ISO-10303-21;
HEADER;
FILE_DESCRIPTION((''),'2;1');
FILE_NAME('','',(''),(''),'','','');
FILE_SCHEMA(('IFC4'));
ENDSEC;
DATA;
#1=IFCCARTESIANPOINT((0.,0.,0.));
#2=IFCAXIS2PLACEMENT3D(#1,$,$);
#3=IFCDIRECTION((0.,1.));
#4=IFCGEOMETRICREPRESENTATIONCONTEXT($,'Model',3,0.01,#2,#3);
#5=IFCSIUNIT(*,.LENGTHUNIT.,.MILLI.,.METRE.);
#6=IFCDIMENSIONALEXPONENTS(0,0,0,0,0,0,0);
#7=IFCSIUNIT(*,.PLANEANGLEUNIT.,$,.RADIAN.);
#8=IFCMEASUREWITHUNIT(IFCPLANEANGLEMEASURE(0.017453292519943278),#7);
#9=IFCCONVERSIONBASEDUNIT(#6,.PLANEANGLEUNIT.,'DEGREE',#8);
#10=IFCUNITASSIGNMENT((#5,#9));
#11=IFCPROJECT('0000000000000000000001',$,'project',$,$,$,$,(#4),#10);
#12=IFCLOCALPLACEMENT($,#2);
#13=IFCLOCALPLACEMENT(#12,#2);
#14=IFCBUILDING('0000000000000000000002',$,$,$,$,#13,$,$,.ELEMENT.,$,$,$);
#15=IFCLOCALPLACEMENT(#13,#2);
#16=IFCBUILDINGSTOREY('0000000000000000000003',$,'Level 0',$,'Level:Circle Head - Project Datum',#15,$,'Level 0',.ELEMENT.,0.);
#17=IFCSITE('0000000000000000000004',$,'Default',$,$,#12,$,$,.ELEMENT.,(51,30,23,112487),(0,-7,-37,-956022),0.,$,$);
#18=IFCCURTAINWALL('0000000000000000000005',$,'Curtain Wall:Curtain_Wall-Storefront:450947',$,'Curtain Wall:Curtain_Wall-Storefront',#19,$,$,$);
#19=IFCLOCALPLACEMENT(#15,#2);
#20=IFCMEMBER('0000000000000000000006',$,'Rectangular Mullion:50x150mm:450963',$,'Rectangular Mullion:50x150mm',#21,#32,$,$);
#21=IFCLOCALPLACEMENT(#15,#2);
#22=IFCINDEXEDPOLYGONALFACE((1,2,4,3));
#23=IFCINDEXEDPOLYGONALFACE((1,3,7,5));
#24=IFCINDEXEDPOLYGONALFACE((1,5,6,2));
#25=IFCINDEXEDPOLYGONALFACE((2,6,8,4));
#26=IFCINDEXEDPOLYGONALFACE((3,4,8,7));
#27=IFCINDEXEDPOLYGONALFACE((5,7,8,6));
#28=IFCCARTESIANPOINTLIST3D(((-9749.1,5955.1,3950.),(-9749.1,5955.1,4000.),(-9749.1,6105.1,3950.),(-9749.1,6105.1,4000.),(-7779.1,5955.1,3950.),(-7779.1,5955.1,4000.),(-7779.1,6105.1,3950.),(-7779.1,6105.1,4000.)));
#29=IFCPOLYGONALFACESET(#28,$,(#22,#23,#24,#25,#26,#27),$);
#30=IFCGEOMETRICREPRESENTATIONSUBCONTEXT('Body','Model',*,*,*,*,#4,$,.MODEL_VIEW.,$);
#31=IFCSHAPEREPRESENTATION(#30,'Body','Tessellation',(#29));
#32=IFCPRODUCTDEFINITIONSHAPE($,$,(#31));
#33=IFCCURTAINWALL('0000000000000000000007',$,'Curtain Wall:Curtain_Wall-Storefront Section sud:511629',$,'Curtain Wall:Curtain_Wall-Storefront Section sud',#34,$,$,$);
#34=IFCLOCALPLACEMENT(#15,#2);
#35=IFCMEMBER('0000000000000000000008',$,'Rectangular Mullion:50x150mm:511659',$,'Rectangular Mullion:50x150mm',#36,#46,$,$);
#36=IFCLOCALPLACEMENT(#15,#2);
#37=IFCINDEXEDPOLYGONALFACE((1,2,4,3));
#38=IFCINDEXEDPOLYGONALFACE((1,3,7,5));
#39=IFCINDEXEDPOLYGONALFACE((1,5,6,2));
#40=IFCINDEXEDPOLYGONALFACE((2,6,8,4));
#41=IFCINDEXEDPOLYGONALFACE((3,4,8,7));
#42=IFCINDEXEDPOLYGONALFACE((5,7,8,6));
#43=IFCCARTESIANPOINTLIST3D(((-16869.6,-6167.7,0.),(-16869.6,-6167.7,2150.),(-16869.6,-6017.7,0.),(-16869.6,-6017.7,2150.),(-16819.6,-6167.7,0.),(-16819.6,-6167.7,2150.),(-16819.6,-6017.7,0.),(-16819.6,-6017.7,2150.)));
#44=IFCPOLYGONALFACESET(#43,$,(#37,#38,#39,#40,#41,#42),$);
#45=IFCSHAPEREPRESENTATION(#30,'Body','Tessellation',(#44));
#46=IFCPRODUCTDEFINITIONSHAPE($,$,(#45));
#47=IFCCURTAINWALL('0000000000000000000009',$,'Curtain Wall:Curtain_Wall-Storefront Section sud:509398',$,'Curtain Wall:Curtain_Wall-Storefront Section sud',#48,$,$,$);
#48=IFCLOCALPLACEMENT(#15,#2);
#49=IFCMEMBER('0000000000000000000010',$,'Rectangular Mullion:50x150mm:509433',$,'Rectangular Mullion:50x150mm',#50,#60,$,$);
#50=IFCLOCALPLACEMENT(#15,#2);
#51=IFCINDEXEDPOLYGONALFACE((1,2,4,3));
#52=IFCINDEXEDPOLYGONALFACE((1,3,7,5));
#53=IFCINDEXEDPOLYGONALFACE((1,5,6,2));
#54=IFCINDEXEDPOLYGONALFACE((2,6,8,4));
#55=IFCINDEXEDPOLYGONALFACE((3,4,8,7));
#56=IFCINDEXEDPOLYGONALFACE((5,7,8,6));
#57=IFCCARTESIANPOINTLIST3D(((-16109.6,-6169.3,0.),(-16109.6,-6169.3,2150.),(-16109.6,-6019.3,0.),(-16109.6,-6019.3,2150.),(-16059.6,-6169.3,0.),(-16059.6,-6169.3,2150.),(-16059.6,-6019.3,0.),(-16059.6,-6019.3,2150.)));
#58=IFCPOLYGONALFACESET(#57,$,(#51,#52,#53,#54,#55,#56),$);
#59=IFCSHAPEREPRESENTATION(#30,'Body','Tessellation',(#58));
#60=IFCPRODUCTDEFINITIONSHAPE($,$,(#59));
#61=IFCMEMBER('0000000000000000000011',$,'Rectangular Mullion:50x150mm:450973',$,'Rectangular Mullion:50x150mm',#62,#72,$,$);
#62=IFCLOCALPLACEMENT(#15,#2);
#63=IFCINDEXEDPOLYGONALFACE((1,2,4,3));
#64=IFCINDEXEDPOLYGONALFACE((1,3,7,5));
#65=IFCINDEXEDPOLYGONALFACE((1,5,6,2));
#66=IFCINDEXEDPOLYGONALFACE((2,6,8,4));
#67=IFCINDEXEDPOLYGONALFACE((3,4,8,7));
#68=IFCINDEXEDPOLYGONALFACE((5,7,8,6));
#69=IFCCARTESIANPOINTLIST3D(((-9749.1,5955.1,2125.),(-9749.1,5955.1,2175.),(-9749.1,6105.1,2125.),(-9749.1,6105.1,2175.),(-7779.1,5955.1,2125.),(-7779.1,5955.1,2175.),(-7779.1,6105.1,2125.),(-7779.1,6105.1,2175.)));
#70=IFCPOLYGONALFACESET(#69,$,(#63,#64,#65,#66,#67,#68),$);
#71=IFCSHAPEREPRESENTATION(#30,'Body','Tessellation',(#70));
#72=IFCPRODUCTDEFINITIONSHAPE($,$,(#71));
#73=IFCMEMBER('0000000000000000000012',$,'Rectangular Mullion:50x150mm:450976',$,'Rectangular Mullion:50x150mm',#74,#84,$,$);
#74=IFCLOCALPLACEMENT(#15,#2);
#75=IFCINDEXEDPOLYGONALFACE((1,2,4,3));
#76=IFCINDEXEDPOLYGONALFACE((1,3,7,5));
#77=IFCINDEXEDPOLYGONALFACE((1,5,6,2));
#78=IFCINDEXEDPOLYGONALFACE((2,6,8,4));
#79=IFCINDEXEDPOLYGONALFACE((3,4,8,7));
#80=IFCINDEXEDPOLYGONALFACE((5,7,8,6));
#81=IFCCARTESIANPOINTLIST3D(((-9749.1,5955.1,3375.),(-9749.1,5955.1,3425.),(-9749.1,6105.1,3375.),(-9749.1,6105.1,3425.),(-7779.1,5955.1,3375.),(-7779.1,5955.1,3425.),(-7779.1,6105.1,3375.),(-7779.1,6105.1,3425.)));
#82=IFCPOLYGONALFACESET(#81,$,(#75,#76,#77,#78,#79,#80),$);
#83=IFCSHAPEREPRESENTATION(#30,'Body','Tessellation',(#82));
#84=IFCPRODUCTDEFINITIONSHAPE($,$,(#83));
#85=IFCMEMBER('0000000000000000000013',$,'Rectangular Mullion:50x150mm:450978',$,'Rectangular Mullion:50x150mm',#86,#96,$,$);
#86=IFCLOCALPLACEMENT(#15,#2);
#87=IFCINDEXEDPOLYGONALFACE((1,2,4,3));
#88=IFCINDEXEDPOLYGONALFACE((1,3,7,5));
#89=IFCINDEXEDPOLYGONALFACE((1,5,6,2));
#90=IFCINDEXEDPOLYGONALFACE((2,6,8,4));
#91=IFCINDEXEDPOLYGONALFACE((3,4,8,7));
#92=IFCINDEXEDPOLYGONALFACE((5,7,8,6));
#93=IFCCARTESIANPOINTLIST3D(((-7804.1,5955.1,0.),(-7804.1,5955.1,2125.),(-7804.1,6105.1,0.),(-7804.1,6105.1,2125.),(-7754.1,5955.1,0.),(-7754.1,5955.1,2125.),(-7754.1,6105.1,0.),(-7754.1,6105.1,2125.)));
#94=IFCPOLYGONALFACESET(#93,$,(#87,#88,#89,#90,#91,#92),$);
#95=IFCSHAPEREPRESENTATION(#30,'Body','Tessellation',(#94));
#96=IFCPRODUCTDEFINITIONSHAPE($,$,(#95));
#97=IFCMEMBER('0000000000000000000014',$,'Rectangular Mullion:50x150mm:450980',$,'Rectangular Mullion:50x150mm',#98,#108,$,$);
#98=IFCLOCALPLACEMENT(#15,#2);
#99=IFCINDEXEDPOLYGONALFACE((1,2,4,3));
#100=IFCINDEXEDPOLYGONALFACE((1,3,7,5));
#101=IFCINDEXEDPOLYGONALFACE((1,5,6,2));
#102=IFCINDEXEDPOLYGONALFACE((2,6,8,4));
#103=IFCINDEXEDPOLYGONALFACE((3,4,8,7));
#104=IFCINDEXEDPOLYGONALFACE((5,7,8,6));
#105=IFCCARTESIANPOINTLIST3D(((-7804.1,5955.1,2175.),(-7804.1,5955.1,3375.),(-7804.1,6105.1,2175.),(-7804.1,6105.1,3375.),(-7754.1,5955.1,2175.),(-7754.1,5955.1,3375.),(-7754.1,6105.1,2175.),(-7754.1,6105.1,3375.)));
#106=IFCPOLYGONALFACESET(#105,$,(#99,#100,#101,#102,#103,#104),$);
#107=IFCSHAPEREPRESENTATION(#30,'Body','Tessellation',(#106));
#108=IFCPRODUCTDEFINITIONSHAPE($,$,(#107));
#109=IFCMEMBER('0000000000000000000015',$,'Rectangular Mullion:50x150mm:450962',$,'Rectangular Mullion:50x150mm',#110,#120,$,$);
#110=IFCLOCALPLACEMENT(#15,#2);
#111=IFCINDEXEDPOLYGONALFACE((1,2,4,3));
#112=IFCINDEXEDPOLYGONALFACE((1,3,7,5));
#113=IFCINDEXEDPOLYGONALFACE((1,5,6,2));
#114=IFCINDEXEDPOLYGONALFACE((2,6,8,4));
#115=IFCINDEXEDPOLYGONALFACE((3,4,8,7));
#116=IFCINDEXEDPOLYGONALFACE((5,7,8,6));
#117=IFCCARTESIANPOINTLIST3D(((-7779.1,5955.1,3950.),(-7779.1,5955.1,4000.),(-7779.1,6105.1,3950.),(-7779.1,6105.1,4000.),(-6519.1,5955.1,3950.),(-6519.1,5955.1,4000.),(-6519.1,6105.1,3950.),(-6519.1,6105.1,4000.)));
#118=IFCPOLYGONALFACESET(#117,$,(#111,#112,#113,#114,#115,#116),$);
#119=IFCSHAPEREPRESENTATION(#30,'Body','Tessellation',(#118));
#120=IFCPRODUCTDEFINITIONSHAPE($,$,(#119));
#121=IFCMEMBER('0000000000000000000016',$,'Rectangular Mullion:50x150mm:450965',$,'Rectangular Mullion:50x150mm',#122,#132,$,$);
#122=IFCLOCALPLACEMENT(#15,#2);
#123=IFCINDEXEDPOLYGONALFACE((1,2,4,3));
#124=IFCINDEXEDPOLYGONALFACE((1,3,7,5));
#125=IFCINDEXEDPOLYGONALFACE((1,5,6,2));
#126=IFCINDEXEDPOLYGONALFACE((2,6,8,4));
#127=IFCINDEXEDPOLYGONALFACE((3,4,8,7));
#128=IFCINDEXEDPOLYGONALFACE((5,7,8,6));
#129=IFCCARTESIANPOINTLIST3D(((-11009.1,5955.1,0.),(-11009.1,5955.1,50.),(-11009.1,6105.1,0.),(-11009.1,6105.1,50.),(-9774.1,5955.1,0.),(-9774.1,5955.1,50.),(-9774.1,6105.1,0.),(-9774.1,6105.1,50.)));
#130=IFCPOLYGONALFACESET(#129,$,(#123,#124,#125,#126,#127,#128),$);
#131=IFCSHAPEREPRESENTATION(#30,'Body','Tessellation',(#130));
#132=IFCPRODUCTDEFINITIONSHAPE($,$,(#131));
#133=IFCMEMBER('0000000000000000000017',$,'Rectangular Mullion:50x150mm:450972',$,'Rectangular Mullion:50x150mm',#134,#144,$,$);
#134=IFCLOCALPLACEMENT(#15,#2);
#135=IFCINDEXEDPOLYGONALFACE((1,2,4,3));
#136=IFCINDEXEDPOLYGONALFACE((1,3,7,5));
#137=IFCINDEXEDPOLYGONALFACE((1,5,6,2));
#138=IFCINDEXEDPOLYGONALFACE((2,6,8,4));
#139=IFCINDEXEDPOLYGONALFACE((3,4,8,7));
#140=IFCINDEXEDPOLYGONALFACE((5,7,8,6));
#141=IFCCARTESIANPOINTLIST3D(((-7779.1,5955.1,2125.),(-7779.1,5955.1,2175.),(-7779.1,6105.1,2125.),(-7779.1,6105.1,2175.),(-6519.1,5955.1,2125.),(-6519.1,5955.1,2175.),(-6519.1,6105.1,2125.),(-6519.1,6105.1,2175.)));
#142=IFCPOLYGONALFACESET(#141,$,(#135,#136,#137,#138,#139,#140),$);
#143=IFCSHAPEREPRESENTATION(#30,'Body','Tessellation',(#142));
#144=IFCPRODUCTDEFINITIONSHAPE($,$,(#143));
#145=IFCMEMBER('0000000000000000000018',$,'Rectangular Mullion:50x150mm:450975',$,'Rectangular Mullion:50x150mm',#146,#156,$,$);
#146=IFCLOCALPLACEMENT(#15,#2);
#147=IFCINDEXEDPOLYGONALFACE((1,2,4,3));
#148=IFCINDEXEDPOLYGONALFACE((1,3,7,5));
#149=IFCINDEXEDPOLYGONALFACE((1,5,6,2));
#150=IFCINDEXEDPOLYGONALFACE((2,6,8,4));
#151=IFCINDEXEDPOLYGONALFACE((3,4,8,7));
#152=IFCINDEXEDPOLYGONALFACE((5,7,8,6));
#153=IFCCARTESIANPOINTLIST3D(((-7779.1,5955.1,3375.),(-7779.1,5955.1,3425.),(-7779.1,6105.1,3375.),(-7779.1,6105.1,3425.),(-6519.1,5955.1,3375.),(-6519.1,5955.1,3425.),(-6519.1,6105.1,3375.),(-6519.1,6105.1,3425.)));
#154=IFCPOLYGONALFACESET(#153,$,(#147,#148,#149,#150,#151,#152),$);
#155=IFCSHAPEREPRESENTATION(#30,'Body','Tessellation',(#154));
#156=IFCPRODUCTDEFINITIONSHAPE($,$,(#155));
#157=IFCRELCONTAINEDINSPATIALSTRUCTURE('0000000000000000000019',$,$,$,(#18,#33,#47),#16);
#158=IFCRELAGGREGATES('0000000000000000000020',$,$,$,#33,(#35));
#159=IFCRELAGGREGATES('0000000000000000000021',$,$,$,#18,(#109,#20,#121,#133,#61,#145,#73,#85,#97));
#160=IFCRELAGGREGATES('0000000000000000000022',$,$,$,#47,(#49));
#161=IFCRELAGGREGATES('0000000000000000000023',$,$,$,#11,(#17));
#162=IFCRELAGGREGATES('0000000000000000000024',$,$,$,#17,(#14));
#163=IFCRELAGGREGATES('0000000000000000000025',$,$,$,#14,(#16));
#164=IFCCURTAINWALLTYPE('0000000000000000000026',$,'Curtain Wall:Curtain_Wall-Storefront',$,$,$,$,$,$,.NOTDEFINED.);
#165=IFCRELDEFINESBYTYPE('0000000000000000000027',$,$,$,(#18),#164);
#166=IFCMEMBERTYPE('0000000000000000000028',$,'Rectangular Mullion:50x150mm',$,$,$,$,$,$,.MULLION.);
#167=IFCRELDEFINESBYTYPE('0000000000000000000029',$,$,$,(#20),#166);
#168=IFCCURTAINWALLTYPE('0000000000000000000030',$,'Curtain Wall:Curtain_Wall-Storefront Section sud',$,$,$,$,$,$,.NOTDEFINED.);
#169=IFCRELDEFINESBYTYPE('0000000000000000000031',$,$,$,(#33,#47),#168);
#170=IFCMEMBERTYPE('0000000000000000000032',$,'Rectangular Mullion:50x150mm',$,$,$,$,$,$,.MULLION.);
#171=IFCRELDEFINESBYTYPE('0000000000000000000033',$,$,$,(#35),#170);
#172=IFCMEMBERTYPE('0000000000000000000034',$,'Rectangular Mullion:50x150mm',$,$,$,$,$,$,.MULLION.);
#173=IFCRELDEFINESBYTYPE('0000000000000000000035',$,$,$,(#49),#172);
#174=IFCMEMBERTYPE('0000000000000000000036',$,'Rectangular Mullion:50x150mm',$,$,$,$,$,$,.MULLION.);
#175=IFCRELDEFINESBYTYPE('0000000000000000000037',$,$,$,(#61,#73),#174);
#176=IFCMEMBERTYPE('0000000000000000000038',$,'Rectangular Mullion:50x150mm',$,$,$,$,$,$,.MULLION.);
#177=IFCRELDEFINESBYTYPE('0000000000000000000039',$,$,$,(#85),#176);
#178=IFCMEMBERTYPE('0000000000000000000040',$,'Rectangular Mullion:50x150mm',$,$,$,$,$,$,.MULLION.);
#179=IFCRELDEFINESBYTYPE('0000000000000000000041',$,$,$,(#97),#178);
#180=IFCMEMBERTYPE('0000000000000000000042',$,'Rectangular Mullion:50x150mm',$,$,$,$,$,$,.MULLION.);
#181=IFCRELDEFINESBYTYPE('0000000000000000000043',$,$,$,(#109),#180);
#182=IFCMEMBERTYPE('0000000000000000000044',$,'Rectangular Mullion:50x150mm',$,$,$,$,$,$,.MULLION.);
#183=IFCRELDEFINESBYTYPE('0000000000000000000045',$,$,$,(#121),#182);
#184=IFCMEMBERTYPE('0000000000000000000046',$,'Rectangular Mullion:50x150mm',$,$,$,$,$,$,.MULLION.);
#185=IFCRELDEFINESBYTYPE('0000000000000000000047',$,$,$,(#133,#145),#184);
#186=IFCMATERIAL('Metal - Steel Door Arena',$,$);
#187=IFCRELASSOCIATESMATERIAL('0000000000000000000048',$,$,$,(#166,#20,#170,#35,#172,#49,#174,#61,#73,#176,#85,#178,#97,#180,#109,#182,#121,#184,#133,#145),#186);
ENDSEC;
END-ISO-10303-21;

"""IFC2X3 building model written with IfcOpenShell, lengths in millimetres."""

from ifc_helpers import new_model, entity, si_unit, converted_unit, direction, frame, origin, origin_2d_with_axis, place, context, subcontext, project, spatial, rectangle, extrude, source, transform, mapped, material, type_object, type_shapes, element, aggregate, save


model = new_model("IFC2X3")

# Units and contexts
model_context = context("Model", 3, precision=0.01, world=origin(), true_north=direction((0.0, 1.0)))
body_context = subcontext(model_context, "Body", "Model", "MODEL_VIEW")
ifc_project = project(units=[si_unit("LENGTHUNIT", "METRE", prefix="MILLI"), converted_unit("PLANEANGLEUNIT", "DEGREE", entity("IfcPlaneAngleMeasure", 0.017453292519943278), si_unit("PLANEANGLEUNIT", "RADIAN"), dimensions=[0, 0, 0, 0, 0, 0, 0])], contexts=[model_context])

# Site, building, storey
site_placement = place(None, origin())
site = spatial("IfcSite", under=ifc_project, at=site_placement, Name="Default", CompositionType="ELEMENT", RefLatitude=(51, 30, 23, 112487), RefLongitude=(0, -7, -37, -956022), RefElevation=0.0)
building_placement = place(site_placement, origin())
building = spatial("IfcBuilding", under=site, at=building_placement, CompositionType="ELEMENT")
storey_placement = place(building_placement, origin())
storey = spatial("IfcBuildingStorey", under=building, at=storey_placement, Name="Level 0", ObjectType="Level:Circle Head - Project Datum", LongName="Level 0", CompositionType="ELEMENT", Elevation=0.0)

# Curtain walls, members
curtain_wall_type_1 = type_object("IfcCurtainWallType", Name="Curtain Wall:Curtain_Wall-Storefront", PredefinedType="NOTDEFINED")
curtain_wall_1_placement = place(storey_placement, origin())
curtain_wall_1 = element("IfcCurtainWall", 1, at=curtain_wall_1_placement, inside=storey, type_object=curtain_wall_type_1, Name="Curtain Wall:Curtain_Wall-Storefront:450947", ObjectType="Curtain Wall:Curtain_Wall-Storefront")
ifc_material_1 = material(Name="Metal - Steel Door Arena")
member_type_1 = type_object("IfcMemberType", Name="Rectangular Mullion:50x150mm", PredefinedType="MULLION", material=ifc_material_1)
shared_shape_1 = source(origin(), body_context, "Body", "SweptSolid", [
    extrude(rectangle(XDim=50.0, YDim=150.0, at=origin_2d_with_axis()), frame((-25.0, 0.0, -1970.0), z_axis=(0.0, 0.0, 1.0), x_axis=(-1.0, 0.0, 0.0)), (0.0, 0.0, 1.0), 1970.0),
])
type_shapes(member_type_1, [shared_shape_1])
member_1_placement = place(curtain_wall_1_placement, frame((-9749.1, 6030.1, 4000.0), z_axis=(-1.0, 0.0, 0.0), x_axis=(0.0, 0.0, 1.0)))
member_1 = element("IfcMember", 2, at=member_1_placement, type_object=member_type_1, material=ifc_material_1, Name="Rectangular Mullion:50x150mm:450963", ObjectType="Rectangular Mullion:50x150mm", context=body_context, shape_type="MappedRepresentation", body=[
    mapped(shared_shape_1, transform((0.0, 0.0, 0.0), scale=1.0)),
])
curtain_wall_type_2 = type_object("IfcCurtainWallType", Name="Curtain Wall:Curtain_Wall-Storefront Section sud", PredefinedType="NOTDEFINED")
curtain_wall_2_placement = place(storey_placement, origin())
curtain_wall_2 = element("IfcCurtainWall", 3, at=curtain_wall_2_placement, inside=storey, type_object=curtain_wall_type_2, Name="Curtain Wall:Curtain_Wall-Storefront Section sud:511629", ObjectType="Curtain Wall:Curtain_Wall-Storefront Section sud")
member_type_2 = type_object("IfcMemberType", Name="Rectangular Mullion:50x150mm", PredefinedType="MULLION", material=ifc_material_1)
shared_shape_2 = source(origin(), body_context, "Body", "SweptSolid", [
    extrude(rectangle(XDim=50.0, YDim=150.0, at=origin_2d_with_axis()), frame((-25.0, 0.0, -2150.0), z_axis=(0.0, 0.0, 1.0), x_axis=(-1.0, 0.0, 0.0)), (0.0, 0.0, 1.0), 2150.0),
])
type_shapes(member_type_2, [shared_shape_2])
member_2_placement = place(curtain_wall_2_placement, frame((-16819.6, -6092.7, 0.0), z_axis=(0.0, 0.0, -1.0), x_axis=(1.0, 0.0, 0.0)))
member_2 = element("IfcMember", 4, at=member_2_placement, type_object=member_type_2, material=ifc_material_1, Name="Rectangular Mullion:50x150mm:511659", ObjectType="Rectangular Mullion:50x150mm", context=body_context, shape_type="MappedRepresentation", body=[
    mapped(shared_shape_2, transform((0.0, 0.0, 0.0), scale=1.0)),
])
curtain_wall_3_placement = place(storey_placement, origin())
curtain_wall_3 = element("IfcCurtainWall", 5, at=curtain_wall_3_placement, inside=storey, type_object=curtain_wall_type_2, Name="Curtain Wall:Curtain_Wall-Storefront Section sud:509398", ObjectType="Curtain Wall:Curtain_Wall-Storefront Section sud")
member_type_3 = type_object("IfcMemberType", Name="Rectangular Mullion:50x150mm", PredefinedType="MULLION", material=ifc_material_1)
shared_shape_3 = source(origin(), body_context, "Body", "SweptSolid", [
    extrude(rectangle(XDim=50.0, YDim=150.0, at=origin_2d_with_axis()), frame((-25.0, 0.0, -2150.0), z_axis=(0.0, 0.0, 1.0), x_axis=(-1.0, 0.0, 0.0)), (0.0, 0.0, 1.0), 2150.0),
])
type_shapes(member_type_3, [shared_shape_3])
member_3_placement = place(curtain_wall_3_placement, frame((-16109.6, -6094.3, 2150.0), z_axis=(0.0, 0.0, 1.0), x_axis=(-1.0, 0.0, 0.0)))
member_3 = element("IfcMember", 6, at=member_3_placement, type_object=member_type_3, material=ifc_material_1, Name="Rectangular Mullion:50x150mm:509433", ObjectType="Rectangular Mullion:50x150mm", context=body_context, shape_type="MappedRepresentation", body=[
    mapped(shared_shape_3, transform((0.0, 0.0, 0.0), scale=1.0)),
])

# Members
member_type_4 = type_object("IfcMemberType", Name="Rectangular Mullion:50x150mm", PredefinedType="MULLION", material=ifc_material_1)
shared_shape_4 = source(origin(), body_context, "Body", "SweptSolid", [
    extrude(rectangle(XDim=50.0, YDim=150.0, at=origin_2d_with_axis()), frame((0.0, 0.0, -1970.0), z_axis=(0.0, 0.0, 1.0), x_axis=(-1.0, 0.0, 0.0)), (0.0, 0.0, 1.0), 1970.0),
])
type_shapes(member_type_4, [shared_shape_4])
member_4_placement = place(curtain_wall_1_placement, frame((-9749.1, 6030.1, 2150.0), z_axis=(-1.0, 0.0, 0.0), x_axis=(0.0, 0.0, 1.0)))
member_4 = element("IfcMember", 7, at=member_4_placement, type_object=member_type_4, material=ifc_material_1, Name="Rectangular Mullion:50x150mm:450973", ObjectType="Rectangular Mullion:50x150mm", context=body_context, shape_type="MappedRepresentation", body=[
    mapped(shared_shape_4, transform((0.0, 0.0, 0.0), scale=1.0)),
])
member_5_placement = place(curtain_wall_1_placement, frame((-9749.1, 6030.1, 3400.0), z_axis=(-1.0, 0.0, 0.0), x_axis=(0.0, 0.0, 1.0)))
member_5 = element("IfcMember", 8, at=member_5_placement, type_object=member_type_4, material=ifc_material_1, Name="Rectangular Mullion:50x150mm:450976", ObjectType="Rectangular Mullion:50x150mm", context=body_context, shape_type="MappedRepresentation", body=[
    mapped(shared_shape_4, transform((0.0, 0.0, 0.0), scale=1.0)),
])
member_type_5 = type_object("IfcMemberType", Name="Rectangular Mullion:50x150mm", PredefinedType="MULLION", material=ifc_material_1)
shared_shape_5 = source(origin(), body_context, "Body", "SweptSolid", [
    extrude(rectangle(XDim=50.0, YDim=150.0, at=origin_2d_with_axis()), frame((0.0, 0.0, -2125.0), z_axis=(0.0, 0.0, 1.0), x_axis=(-1.0, 0.0, 0.0)), (0.0, 0.0, 1.0), 2125.0),
])
type_shapes(member_type_5, [shared_shape_5])
member_6_placement = place(curtain_wall_1_placement, frame((-7779.1, 6030.1, 0.0), z_axis=(0.0, 0.0, -1.0), x_axis=(-1.0, 0.0, 0.0)))
member_6 = element("IfcMember", 9, at=member_6_placement, type_object=member_type_5, material=ifc_material_1, Name="Rectangular Mullion:50x150mm:450978", ObjectType="Rectangular Mullion:50x150mm", context=body_context, shape_type="MappedRepresentation", body=[
    mapped(shared_shape_5, transform((0.0, 0.0, 0.0), scale=1.0)),
])
member_type_6 = type_object("IfcMemberType", Name="Rectangular Mullion:50x150mm", PredefinedType="MULLION", material=ifc_material_1)
shared_shape_6 = source(origin(), body_context, "Body", "SweptSolid", [
    extrude(rectangle(XDim=50.0, YDim=150.0, at=origin_2d_with_axis()), frame((0.0, 0.0, -1200.0), z_axis=(0.0, 0.0, 1.0), x_axis=(-1.0, 0.0, 0.0)), (0.0, 0.0, 1.0), 1200.0),
])
type_shapes(member_type_6, [shared_shape_6])
member_7_placement = place(curtain_wall_1_placement, frame((-7779.1, 6030.1, 2175.0), z_axis=(0.0, 0.0, -1.0), x_axis=(-1.0, 0.0, 0.0)))
member_7 = element("IfcMember", 10, at=member_7_placement, type_object=member_type_6, material=ifc_material_1, Name="Rectangular Mullion:50x150mm:450980", ObjectType="Rectangular Mullion:50x150mm", context=body_context, shape_type="MappedRepresentation", body=[
    mapped(shared_shape_6, transform((0.0, 0.0, 0.0), scale=1.0)),
])
member_type_7 = type_object("IfcMemberType", Name="Rectangular Mullion:50x150mm", PredefinedType="MULLION", material=ifc_material_1)
shared_shape_7 = source(origin(), body_context, "Body", "SweptSolid", [
    extrude(rectangle(XDim=50.0, YDim=150.0, at=origin_2d_with_axis()), frame((-25.0, 0.0, -1260.0), z_axis=(0.0, 0.0, 1.0), x_axis=(-1.0, 0.0, 0.0)), (0.0, 0.0, 1.0), 1260.0),
])
type_shapes(member_type_7, [shared_shape_7])
member_8_placement = place(curtain_wall_1_placement, frame((-7779.1, 6030.1, 4000.0), z_axis=(-1.0, 0.0, 0.0), x_axis=(0.0, 0.0, 1.0)))
member_8 = element("IfcMember", 11, at=member_8_placement, type_object=member_type_7, material=ifc_material_1, Name="Rectangular Mullion:50x150mm:450962", ObjectType="Rectangular Mullion:50x150mm", context=body_context, shape_type="MappedRepresentation", body=[
    mapped(shared_shape_7, transform((0.0, 0.0, 0.0), scale=1.0)),
])
member_type_8 = type_object("IfcMemberType", Name="Rectangular Mullion:50x150mm", PredefinedType="MULLION", material=ifc_material_1)
shared_shape_8 = source(origin(), body_context, "Body", "SweptSolid", [
    extrude(rectangle(XDim=50.0, YDim=150.0, at=origin_2d_with_axis()), frame((-25.0, 0.0, -1235.0), z_axis=(0.0, 0.0, 1.0), x_axis=(-1.0, 0.0, 0.0)), (0.0, 0.0, 1.0), 1235.0),
])
type_shapes(member_type_8, [shared_shape_8])
member_9_placement = place(curtain_wall_1_placement, frame((-9774.1, 6030.1, 0.0), z_axis=(1.0, 0.0, 0.0), x_axis=(0.0, 0.0, -1.0)))
member_9 = element("IfcMember", 12, at=member_9_placement, type_object=member_type_8, material=ifc_material_1, Name="Rectangular Mullion:50x150mm:450965", ObjectType="Rectangular Mullion:50x150mm", context=body_context, shape_type="MappedRepresentation", body=[
    mapped(shared_shape_8, transform((0.0, 0.0, 0.0), scale=1.0)),
])
member_type_9 = type_object("IfcMemberType", Name="Rectangular Mullion:50x150mm", PredefinedType="MULLION", material=ifc_material_1)
shared_shape_9 = source(origin(), body_context, "Body", "SweptSolid", [
    extrude(rectangle(XDim=50.0, YDim=150.0, at=origin_2d_with_axis()), frame((0.0, 0.0, -1260.0), z_axis=(0.0, 0.0, 1.0), x_axis=(-1.0, 0.0, 0.0)), (0.0, 0.0, 1.0), 1260.0),
])
type_shapes(member_type_9, [shared_shape_9])
member_10_placement = place(curtain_wall_1_placement, frame((-7779.1, 6030.1, 2150.0), z_axis=(-1.0, 0.0, 0.0), x_axis=(0.0, 0.0, 1.0)))
member_10 = element("IfcMember", 13, at=member_10_placement, type_object=member_type_9, material=ifc_material_1, Name="Rectangular Mullion:50x150mm:450972", ObjectType="Rectangular Mullion:50x150mm", context=body_context, shape_type="MappedRepresentation", body=[
    mapped(shared_shape_9, transform((0.0, 0.0, 0.0), scale=1.0)),
])
member_11_placement = place(curtain_wall_1_placement, frame((-7779.1, 6030.1, 3400.0), z_axis=(-1.0, 0.0, 0.0), x_axis=(0.0, 0.0, 1.0)))
member_11 = element("IfcMember", 14, at=member_11_placement, type_object=member_type_9, material=ifc_material_1, Name="Rectangular Mullion:50x150mm:450975", ObjectType="Rectangular Mullion:50x150mm", context=body_context, shape_type="MappedRepresentation", body=[
    mapped(shared_shape_9, transform((0.0, 0.0, 0.0), scale=1.0)),
])
aggregate(curtain_wall_2, [member_2])

aggregate(curtain_wall_1, [member_8, member_1, member_9, member_10, member_4, member_11, member_5, member_6, member_7])
aggregate(curtain_wall_3, [member_3])

save(model, "model.ifc")
